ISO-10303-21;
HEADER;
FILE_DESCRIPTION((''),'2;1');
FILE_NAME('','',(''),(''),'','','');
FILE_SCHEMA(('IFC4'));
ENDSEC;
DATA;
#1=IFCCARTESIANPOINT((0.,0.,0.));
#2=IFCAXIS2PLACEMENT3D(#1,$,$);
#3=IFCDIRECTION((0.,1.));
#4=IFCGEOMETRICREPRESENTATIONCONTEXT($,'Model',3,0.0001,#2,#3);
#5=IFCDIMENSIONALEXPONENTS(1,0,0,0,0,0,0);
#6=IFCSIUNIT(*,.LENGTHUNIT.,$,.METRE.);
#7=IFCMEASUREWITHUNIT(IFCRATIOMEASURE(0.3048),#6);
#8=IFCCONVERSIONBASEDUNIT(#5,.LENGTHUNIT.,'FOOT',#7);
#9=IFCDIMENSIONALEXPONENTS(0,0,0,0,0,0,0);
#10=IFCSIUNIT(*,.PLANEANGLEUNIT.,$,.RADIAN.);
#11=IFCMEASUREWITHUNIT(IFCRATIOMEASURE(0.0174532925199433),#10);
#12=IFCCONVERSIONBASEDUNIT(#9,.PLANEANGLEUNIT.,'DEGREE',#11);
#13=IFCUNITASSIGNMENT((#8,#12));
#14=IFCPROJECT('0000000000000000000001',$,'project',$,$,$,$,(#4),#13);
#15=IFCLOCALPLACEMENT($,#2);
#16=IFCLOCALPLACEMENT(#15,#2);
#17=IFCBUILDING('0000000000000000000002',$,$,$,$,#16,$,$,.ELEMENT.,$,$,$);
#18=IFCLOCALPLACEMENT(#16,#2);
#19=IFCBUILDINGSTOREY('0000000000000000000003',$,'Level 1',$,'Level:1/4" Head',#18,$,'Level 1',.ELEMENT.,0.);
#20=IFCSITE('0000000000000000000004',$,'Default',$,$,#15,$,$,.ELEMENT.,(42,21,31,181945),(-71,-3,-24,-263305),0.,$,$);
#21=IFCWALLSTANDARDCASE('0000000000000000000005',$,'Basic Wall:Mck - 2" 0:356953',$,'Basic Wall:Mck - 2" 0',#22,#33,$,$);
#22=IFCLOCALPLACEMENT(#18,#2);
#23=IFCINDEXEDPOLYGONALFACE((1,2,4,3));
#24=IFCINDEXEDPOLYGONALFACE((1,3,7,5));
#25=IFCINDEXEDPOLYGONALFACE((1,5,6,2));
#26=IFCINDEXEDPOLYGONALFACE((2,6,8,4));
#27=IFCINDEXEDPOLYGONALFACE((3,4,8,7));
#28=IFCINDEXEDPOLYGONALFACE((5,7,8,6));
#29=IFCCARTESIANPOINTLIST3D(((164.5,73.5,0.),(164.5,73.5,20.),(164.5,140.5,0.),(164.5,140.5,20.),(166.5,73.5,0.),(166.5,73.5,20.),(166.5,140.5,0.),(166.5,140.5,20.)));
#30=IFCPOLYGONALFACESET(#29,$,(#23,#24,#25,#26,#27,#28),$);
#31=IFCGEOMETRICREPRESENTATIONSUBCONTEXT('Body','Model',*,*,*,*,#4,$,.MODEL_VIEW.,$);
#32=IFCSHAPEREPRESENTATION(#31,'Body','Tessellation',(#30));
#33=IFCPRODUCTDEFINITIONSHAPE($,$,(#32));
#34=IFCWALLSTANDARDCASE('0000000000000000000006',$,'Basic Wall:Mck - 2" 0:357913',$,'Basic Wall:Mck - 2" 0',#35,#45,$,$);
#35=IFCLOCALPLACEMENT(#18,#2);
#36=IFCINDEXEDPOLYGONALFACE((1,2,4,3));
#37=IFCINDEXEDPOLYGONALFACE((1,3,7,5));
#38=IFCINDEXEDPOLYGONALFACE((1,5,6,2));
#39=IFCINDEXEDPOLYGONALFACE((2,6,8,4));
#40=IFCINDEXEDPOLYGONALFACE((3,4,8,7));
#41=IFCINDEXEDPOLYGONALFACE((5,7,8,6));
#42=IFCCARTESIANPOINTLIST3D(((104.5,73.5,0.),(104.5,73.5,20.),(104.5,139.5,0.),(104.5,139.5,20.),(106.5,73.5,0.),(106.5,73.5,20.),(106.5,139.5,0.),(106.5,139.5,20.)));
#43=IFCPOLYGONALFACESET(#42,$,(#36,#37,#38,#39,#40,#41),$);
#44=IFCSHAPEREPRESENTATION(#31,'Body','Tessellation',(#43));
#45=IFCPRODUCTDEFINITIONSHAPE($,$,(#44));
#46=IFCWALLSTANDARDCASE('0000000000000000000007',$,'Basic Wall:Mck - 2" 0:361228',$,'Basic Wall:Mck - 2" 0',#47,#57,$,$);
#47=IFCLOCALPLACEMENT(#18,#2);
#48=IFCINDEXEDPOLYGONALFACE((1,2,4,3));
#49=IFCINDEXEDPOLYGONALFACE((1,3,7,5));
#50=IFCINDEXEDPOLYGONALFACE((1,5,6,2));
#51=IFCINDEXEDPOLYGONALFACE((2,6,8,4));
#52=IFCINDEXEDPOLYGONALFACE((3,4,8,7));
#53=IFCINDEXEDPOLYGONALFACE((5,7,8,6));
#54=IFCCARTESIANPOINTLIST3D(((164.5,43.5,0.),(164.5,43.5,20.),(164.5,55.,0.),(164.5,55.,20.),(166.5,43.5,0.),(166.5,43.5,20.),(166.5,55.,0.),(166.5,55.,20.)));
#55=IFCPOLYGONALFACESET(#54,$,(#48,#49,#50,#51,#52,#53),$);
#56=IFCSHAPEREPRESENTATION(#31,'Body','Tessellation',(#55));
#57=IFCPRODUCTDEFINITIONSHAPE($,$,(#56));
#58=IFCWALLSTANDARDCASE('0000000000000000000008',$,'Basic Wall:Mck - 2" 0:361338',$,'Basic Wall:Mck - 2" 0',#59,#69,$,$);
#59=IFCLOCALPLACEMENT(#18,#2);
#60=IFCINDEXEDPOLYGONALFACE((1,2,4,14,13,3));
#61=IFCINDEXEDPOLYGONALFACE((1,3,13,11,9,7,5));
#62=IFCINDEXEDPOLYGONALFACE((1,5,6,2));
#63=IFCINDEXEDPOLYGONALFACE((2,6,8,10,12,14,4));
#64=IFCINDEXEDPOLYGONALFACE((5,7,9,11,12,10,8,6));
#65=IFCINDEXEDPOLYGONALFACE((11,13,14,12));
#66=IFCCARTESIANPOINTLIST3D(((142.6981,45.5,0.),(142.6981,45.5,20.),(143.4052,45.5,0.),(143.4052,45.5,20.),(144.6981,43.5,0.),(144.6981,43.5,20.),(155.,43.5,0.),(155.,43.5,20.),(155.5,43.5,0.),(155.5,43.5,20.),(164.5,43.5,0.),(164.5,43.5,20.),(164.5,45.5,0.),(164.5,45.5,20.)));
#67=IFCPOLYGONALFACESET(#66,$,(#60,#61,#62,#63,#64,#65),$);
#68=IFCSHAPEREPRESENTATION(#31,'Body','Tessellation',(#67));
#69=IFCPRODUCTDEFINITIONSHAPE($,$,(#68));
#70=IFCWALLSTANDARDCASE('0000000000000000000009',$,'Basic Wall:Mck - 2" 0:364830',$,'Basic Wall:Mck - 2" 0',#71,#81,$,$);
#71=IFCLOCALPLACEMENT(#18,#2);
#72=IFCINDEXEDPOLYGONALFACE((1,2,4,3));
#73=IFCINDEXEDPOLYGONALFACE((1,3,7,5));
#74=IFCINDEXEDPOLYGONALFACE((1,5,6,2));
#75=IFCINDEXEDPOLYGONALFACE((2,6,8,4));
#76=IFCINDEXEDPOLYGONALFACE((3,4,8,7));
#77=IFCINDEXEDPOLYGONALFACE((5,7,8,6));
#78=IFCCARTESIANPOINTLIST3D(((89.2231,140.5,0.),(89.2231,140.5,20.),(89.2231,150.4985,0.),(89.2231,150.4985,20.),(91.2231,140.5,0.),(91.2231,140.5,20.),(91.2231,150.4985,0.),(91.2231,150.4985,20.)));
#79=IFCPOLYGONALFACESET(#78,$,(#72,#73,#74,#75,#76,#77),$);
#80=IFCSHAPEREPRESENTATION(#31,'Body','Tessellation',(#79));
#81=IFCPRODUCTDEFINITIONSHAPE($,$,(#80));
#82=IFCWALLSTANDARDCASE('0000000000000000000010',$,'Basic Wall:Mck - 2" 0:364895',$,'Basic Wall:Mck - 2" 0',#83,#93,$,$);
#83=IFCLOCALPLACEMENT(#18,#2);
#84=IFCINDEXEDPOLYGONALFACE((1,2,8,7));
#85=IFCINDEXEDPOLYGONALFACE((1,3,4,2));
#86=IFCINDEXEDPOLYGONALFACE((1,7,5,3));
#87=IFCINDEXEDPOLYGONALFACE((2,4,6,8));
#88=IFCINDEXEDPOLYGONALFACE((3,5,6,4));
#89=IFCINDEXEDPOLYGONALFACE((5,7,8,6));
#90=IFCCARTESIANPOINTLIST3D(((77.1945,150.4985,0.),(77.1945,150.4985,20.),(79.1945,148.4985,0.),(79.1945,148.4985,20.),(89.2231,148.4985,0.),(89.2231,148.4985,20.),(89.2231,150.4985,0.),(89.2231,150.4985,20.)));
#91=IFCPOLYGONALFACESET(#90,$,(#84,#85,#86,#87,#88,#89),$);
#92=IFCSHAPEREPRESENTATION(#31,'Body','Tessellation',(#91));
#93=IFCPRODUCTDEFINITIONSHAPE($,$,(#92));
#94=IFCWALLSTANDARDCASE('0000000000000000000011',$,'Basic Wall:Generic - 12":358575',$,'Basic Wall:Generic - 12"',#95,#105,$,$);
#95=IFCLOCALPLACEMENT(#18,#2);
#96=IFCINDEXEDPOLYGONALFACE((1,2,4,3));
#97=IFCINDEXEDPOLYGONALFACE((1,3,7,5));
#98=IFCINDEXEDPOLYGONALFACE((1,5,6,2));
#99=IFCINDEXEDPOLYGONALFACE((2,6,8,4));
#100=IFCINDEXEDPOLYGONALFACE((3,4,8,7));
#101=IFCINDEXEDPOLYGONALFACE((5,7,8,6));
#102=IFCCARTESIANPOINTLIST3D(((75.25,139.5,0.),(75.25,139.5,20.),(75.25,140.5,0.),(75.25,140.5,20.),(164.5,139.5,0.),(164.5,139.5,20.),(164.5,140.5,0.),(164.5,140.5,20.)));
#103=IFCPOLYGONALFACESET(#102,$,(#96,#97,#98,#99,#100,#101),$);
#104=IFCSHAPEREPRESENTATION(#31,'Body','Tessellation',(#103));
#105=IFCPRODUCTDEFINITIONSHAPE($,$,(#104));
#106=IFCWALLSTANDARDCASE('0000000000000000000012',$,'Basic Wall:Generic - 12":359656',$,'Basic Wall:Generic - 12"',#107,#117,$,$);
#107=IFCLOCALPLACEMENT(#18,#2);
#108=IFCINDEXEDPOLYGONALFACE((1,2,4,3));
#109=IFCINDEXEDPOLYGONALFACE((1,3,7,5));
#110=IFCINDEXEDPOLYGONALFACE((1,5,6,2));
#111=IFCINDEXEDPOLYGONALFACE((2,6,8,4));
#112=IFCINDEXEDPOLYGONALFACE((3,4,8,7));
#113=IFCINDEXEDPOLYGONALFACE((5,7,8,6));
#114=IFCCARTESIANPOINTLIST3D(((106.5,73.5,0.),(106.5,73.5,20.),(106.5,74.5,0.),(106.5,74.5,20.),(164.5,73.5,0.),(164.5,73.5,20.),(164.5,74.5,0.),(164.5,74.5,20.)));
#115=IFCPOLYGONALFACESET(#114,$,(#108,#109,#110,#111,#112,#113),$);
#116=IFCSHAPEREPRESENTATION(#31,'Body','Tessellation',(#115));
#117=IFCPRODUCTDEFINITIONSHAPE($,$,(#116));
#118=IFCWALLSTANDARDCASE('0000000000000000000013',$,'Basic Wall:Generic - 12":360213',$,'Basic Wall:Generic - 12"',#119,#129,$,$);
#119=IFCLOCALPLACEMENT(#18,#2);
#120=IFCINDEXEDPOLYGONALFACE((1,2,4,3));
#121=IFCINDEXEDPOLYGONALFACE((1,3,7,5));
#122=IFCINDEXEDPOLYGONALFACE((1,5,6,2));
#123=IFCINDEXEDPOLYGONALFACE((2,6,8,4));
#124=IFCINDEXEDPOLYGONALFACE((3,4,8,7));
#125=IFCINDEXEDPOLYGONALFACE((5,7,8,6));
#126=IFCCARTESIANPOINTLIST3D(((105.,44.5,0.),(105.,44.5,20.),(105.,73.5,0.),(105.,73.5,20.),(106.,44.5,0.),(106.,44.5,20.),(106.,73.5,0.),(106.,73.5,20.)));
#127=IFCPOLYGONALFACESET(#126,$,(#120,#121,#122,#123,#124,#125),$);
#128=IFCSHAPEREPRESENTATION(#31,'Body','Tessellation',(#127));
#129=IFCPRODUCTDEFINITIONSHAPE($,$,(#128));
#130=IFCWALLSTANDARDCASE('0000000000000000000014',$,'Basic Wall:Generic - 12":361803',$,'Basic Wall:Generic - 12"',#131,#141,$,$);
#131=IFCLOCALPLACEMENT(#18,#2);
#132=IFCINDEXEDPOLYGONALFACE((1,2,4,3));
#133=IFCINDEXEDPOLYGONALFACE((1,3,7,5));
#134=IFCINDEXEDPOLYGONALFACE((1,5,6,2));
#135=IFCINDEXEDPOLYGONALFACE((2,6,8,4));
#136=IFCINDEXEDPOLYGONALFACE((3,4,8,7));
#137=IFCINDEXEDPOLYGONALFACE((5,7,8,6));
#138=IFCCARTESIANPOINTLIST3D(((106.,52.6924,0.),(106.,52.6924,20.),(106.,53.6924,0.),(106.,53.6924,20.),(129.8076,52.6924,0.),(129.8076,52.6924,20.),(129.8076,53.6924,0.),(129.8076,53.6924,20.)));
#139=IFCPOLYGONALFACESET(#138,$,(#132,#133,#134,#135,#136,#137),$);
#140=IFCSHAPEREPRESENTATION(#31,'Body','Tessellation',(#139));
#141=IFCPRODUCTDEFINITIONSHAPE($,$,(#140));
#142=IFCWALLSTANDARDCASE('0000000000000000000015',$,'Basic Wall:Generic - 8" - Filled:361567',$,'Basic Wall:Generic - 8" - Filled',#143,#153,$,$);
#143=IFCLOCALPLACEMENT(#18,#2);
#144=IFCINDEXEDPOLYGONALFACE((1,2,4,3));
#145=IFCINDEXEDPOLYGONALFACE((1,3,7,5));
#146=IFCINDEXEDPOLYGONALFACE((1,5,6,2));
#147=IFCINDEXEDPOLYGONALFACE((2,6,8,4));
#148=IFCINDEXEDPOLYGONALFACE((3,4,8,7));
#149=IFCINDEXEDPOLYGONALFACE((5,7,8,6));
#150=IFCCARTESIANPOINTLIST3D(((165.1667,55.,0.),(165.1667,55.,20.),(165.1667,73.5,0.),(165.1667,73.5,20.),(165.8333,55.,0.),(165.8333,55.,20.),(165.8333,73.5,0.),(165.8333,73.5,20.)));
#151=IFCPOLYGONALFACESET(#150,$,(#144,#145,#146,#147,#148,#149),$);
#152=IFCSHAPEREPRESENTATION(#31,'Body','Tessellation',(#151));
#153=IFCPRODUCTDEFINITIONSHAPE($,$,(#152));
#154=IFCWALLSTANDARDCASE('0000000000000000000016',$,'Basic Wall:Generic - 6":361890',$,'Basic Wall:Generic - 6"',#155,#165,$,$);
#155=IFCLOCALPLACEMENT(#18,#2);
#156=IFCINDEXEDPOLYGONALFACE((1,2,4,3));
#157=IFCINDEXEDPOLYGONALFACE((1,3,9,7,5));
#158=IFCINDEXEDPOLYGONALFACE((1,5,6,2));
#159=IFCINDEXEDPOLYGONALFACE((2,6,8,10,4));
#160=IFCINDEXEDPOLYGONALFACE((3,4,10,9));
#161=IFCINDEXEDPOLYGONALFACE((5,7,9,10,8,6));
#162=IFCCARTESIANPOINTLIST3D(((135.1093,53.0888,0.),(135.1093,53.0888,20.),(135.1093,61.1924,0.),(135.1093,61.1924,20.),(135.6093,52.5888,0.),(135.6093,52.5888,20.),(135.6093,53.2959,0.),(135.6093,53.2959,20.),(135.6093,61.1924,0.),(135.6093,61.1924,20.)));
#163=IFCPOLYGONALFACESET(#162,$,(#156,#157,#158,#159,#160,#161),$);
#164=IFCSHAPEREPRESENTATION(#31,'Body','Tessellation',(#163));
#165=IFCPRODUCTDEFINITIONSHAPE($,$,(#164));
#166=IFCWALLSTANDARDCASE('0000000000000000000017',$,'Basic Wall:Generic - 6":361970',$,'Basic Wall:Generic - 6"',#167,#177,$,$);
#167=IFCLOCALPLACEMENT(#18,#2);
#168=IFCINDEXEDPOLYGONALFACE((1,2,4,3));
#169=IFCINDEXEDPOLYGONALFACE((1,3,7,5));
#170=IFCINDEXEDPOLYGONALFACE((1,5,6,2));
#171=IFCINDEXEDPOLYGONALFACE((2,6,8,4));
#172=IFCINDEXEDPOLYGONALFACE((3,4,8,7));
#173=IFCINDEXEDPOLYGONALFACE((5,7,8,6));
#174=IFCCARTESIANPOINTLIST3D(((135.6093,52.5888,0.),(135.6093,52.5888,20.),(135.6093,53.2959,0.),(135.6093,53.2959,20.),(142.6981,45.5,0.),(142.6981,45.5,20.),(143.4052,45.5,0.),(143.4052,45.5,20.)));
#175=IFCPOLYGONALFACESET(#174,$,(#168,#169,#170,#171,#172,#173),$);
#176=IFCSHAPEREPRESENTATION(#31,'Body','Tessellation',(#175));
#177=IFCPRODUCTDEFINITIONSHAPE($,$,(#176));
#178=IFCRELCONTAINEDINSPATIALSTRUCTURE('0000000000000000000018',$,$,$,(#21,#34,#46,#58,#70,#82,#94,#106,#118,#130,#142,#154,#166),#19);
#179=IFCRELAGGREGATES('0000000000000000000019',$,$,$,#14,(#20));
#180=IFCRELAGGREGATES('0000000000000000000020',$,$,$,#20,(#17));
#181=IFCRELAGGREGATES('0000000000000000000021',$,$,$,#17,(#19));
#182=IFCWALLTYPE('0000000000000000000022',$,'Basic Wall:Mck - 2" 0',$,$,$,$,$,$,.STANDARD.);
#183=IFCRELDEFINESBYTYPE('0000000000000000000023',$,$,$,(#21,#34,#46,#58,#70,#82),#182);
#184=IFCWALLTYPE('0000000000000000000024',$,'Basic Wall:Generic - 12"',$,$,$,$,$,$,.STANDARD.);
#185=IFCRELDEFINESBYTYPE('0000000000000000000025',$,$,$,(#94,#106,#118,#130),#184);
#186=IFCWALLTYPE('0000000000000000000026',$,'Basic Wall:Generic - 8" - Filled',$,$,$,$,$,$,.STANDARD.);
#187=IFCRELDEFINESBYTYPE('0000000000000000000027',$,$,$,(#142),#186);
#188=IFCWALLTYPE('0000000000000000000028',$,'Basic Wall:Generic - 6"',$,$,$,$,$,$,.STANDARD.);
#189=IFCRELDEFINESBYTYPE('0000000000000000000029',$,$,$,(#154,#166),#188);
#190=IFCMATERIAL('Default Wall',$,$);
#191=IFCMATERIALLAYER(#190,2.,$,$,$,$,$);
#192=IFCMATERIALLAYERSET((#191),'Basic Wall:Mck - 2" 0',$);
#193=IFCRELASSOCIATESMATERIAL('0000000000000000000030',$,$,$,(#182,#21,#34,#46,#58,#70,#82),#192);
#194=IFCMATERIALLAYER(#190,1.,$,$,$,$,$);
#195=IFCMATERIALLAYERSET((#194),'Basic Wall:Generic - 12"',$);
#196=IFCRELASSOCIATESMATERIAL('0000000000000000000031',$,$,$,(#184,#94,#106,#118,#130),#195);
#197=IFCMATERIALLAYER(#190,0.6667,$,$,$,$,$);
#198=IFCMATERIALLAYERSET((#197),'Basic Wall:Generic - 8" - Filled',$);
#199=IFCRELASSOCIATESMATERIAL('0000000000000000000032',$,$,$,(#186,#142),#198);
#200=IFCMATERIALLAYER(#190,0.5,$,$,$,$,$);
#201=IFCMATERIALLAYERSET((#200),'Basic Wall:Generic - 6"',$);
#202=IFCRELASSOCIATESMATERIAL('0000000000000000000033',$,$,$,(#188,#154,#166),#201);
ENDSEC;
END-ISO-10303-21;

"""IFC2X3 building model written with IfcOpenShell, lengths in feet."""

from ifc_helpers import new_model, entity, si_unit, converted_unit, direction, frame, frame_2d, origin, place, context, subcontext, project, spatial, polyline, rectangle, outline, extrude, material, layer, layer_set, layer_usage, type_object, element, save


model = new_model("IFC2X3")

# Units and contexts
model_context = context("Model", 3, precision=0.0001, world=origin(), true_north=direction((0.0, 1.0)))
body_context = subcontext(model_context, "Body", "Model", "MODEL_VIEW")
ifc_project = project(units=[converted_unit("LENGTHUNIT", "FOOT", entity("IfcRatioMeasure", 0.3048), si_unit("LENGTHUNIT", "METRE"), dimensions=[1, 0, 0, 0, 0, 0, 0]), converted_unit("PLANEANGLEUNIT", "DEGREE", entity("IfcRatioMeasure", 0.0174532925199433), si_unit("PLANEANGLEUNIT", "RADIAN"), dimensions=[0, 0, 0, 0, 0, 0, 0])], contexts=[model_context])

# Site, building, storey
site_placement = place(None, origin())
site = spatial("IfcSite", under=ifc_project, at=site_placement, Name="Default", CompositionType="ELEMENT", RefLatitude=(42, 21, 31, 181945), RefLongitude=(-71, -3, -24, -263305), RefElevation=0.0)
building_placement = place(site_placement, origin())
building = spatial("IfcBuilding", under=site, at=building_placement, CompositionType="ELEMENT")
storey_placement = place(building_placement, origin())
storey = spatial("IfcBuildingStorey", under=building, at=storey_placement, Name="Level 1", ObjectType="Level:1/4\" Head", LongName="Level 1", CompositionType="ELEMENT", Elevation=0.0)

# Walls
ifc_material = material(Name="Default Wall")
ifc_layer_1 = layer(ifc_material, 2.0)
ifc_layer_set_1 = layer_set([ifc_layer_1], Name="Basic Wall:Mck - 2\" 0")
ifc_layer_usage_1 = layer_usage(ifc_layer_set_1, "AXIS2", "NEGATIVE", 1.0)
wall_type_1 = type_object("IfcWallType", Name="Basic Wall:Mck - 2\" 0", PredefinedType="STANDARD", material=ifc_layer_set_1)
wall_1_placement = place(storey_placement, frame((165.5, 140.5, 0.0), z_axis=(0.0, 0.0, 1.0), x_axis=(0.0, -1.0, 0.0)))
element("IfcWallStandardCase", 1, at=wall_1_placement, inside=storey, type_object=wall_type_1, material=ifc_layer_usage_1, Name="Basic Wall:Mck - 2\" 0:356953", ObjectType="Basic Wall:Mck - 2\" 0", context=body_context, shape_type="SweptSolid", body=[
    extrude(rectangle(XDim=67.0, YDim=2.0, at=frame_2d((33.5, 0.0), x_axis=(-1.0, 0.0))), origin(), (0.0, 0.0, 1.0), 20.0),
])
ifc_layer_usage_2 = layer_usage(ifc_layer_set_1, "AXIS2", "NEGATIVE", 1.0)
wall_2_placement = place(storey_placement, frame((105.5, 139.5, 0.0), z_axis=(0.0, 0.0, 1.0), x_axis=(0.0, -1.0, 0.0)))
element("IfcWallStandardCase", 2, at=wall_2_placement, inside=storey, type_object=wall_type_1, material=ifc_layer_usage_2, Name="Basic Wall:Mck - 2\" 0:357913", ObjectType="Basic Wall:Mck - 2\" 0", context=body_context, shape_type="SweptSolid", body=[
    extrude(rectangle(XDim=66.0, YDim=2.0, at=frame_2d((33.0, 0.0), x_axis=(-1.0, 0.0))), origin(), (0.0, 0.0, 1.0), 20.0),
])
ifc_layer_usage_3 = layer_usage(ifc_layer_set_1, "AXIS2", "NEGATIVE", 1.0)
wall_3_placement = place(storey_placement, frame((165.5, 55.0, 0.0), z_axis=(0.0, 0.0, 1.0), x_axis=(0.0, -1.0, 0.0)))
element("IfcWallStandardCase", 3, at=wall_3_placement, inside=storey, type_object=wall_type_1, material=ifc_layer_usage_3, Name="Basic Wall:Mck - 2\" 0:361228", ObjectType="Basic Wall:Mck - 2\" 0", context=body_context, shape_type="SweptSolid", body=[
    extrude(rectangle(XDim=11.5, YDim=2.0, at=frame_2d((5.75, 0.0), x_axis=(-1.0, 0.0))), origin(), (0.0, 0.0, 1.0), 20.0),
])
ifc_layer_usage_4 = layer_usage(ifc_layer_set_1, "AXIS2", "NEGATIVE", 1.0)
wall_4_placement = place(storey_placement, frame((164.5, 44.5, 0.0), z_axis=(0.0, 0.0, 1.0), x_axis=(-1.0, 0.0, 0.0)))
element("IfcWallStandardCase", 4, at=wall_4_placement, inside=storey, type_object=wall_type_1, material=ifc_layer_usage_4, Name="Basic Wall:Mck - 2\" 0:361338", ObjectType="Basic Wall:Mck - 2\" 0", context=body_context, shape_type="SweptSolid", body=[
    extrude(outline(polyline([(21.8019, -1.0), (19.8019, 1.0), (9.5, 1.0), (9.0, 1.0), (0.0, 1.0), (0.0, -1.0), (21.0948, -1.0), (21.8019, -1.0)])), origin(), (0.0, 0.0, 1.0), 20.0),
])
ifc_layer_usage_5 = layer_usage(ifc_layer_set_1, "AXIS2", "NEGATIVE", 1.0)
wall_5_placement = place(storey_placement, frame((90.2231, 140.5, 0.0), z_axis=(0.0, 0.0, 1.0), x_axis=(0.0, 1.0, 0.0)))
element("IfcWallStandardCase", 5, at=wall_5_placement, inside=storey, type_object=wall_type_1, material=ifc_layer_usage_5, Name="Basic Wall:Mck - 2\" 0:364830", ObjectType="Basic Wall:Mck - 2\" 0", context=body_context, shape_type="SweptSolid", body=[
    extrude(rectangle(XDim=9.9985, YDim=2.0, at=frame_2d((4.9992, 0.0), x_axis=(-1.0, 0.0))), origin(), (0.0, 0.0, 1.0), 20.0),
])
ifc_layer_usage_6 = layer_usage(ifc_layer_set_1, "AXIS2", "NEGATIVE", 1.0)
wall_6_placement = place(storey_placement, frame((89.2231, 149.4985, 0.0), z_axis=(0.0, 0.0, 1.0), x_axis=(-1.0, 0.0, 0.0)))
element("IfcWallStandardCase", 6, at=wall_6_placement, inside=storey, type_object=wall_type_1, material=ifc_layer_usage_6, Name="Basic Wall:Mck - 2\" 0:364895", ObjectType="Basic Wall:Mck - 2\" 0", context=body_context, shape_type="SweptSolid", body=[
    extrude(outline(polyline([(12.0286, -1.0), (10.0286, 1.0), (0.0, 1.0), (0.0, -1.0), (12.0286, -1.0)])), origin(), (0.0, 0.0, 1.0), 20.0),
])
ifc_layer_2 = layer(ifc_material, 1.0)
ifc_layer_set_2 = layer_set([ifc_layer_2], Name="Basic Wall:Generic - 12\"")
ifc_layer_usage_7 = layer_usage(ifc_layer_set_2, "AXIS2", "NEGATIVE", 0.5)
wall_type_2 = type_object("IfcWallType", Name="Basic Wall:Generic - 12\"", PredefinedType="STANDARD", material=ifc_layer_set_2)
wall_7_placement = place(storey_placement, frame((75.25, 140.0, 0.0)))
element("IfcWallStandardCase", 7, at=wall_7_placement, inside=storey, type_object=wall_type_2, material=ifc_layer_usage_7, Name="Basic Wall:Generic - 12\":358575", ObjectType="Basic Wall:Generic - 12\"", context=body_context, shape_type="SweptSolid", body=[
    extrude(rectangle(XDim=89.25, YDim=1.0, at=frame_2d((44.625, 0.0), x_axis=(-1.0, 0.0))), origin(), (0.0, 0.0, 1.0), 20.0),
])
ifc_layer_usage_8 = layer_usage(ifc_layer_set_2, "AXIS2", "NEGATIVE", 0.5)
wall_8_placement = place(storey_placement, frame((106.5, 74.0, 0.0)))
element("IfcWallStandardCase", 8, at=wall_8_placement, inside=storey, type_object=wall_type_2, material=ifc_layer_usage_8, Name="Basic Wall:Generic - 12\":359656", ObjectType="Basic Wall:Generic - 12\"", context=body_context, shape_type="SweptSolid", body=[
    extrude(rectangle(XDim=58.0, YDim=1.0, at=frame_2d((29.0, 0.0), x_axis=(-1.0, 0.0))), origin(), (0.0, 0.0, 1.0), 20.0),
])
ifc_layer_usage_9 = layer_usage(ifc_layer_set_2, "AXIS2", "NEGATIVE", 0.5)
wall_9_placement = place(storey_placement, frame((105.5, 44.5, 0.0), z_axis=(0.0, 0.0, 1.0), x_axis=(0.0, 1.0, 0.0)))
element("IfcWallStandardCase", 9, at=wall_9_placement, inside=storey, type_object=wall_type_2, material=ifc_layer_usage_9, Name="Basic Wall:Generic - 12\":360213", ObjectType="Basic Wall:Generic - 12\"", context=body_context, shape_type="SweptSolid", body=[
    extrude(rectangle(XDim=29.0, YDim=1.0, at=frame_2d((14.5, 0.0), x_axis=(-1.0, 0.0))), origin(), (0.0, 0.0, 1.0), 20.0),
])
ifc_layer_usage_10 = layer_usage(ifc_layer_set_2, "AXIS2", "NEGATIVE", 0.5)
wall_10_placement = place(storey_placement, frame((129.8076, 53.1924, 0.0), z_axis=(0.0, 0.0, 1.0), x_axis=(-1.0, 0.0, 0.0)))
element("IfcWallStandardCase", 10, at=wall_10_placement, inside=storey, type_object=wall_type_2, material=ifc_layer_usage_10, Name="Basic Wall:Generic - 12\":361803", ObjectType="Basic Wall:Generic - 12\"", context=body_context, shape_type="SweptSolid", body=[
    extrude(rectangle(XDim=23.8076, YDim=1.0, at=frame_2d((11.9038, 0.0), x_axis=(-1.0, 0.0))), origin(), (0.0, 0.0, 1.0), 20.0),
])
ifc_layer_3 = layer(ifc_material, 0.6667)
ifc_layer_set_3 = layer_set([ifc_layer_3], Name="Basic Wall:Generic - 8\" - Filled")
ifc_layer_usage_11 = layer_usage(ifc_layer_set_3, "AXIS2", "NEGATIVE", 0.3333)
wall_type_3 = type_object("IfcWallType", Name="Basic Wall:Generic - 8\" - Filled", PredefinedType="STANDARD", material=ifc_layer_set_3)
wall_11_placement = place(storey_placement, frame((165.5, 55.0, 0.0), z_axis=(0.0, 0.0, 1.0), x_axis=(0.0, 1.0, 0.0)))
element("IfcWallStandardCase", 11, at=wall_11_placement, inside=storey, type_object=wall_type_3, material=ifc_layer_usage_11, Name="Basic Wall:Generic - 8\" - Filled:361567", ObjectType="Basic Wall:Generic - 8\" - Filled", context=body_context, shape_type="SweptSolid", body=[
    extrude(rectangle(XDim=18.5, YDim=0.6667, at=frame_2d((9.25, 0.0), x_axis=(-1.0, 0.0))), origin(), (0.0, 0.0, 1.0), 20.0),
])
ifc_layer_4 = layer(ifc_material, 0.5)
ifc_layer_set_4 = layer_set([ifc_layer_4], Name="Basic Wall:Generic - 6\"")
ifc_layer_usage_12 = layer_usage(ifc_layer_set_4, "AXIS2", "NEGATIVE", 0.25)
wall_type_4 = type_object("IfcWallType", Name="Basic Wall:Generic - 6\"", PredefinedType="STANDARD", material=ifc_layer_set_4)
wall_12_placement = place(storey_placement, frame((135.3593, 61.1924, 0.0), z_axis=(0.0, 0.0, 1.0), x_axis=(0.0, -1.0, 0.0)))
element("IfcWallStandardCase", 12, at=wall_12_placement, inside=storey, type_object=wall_type_4, material=ifc_layer_usage_12, Name="Basic Wall:Generic - 6\":361890", ObjectType="Basic Wall:Generic - 6\"", context=body_context, shape_type="SweptSolid", body=[
    extrude(outline(polyline([(8.1036, -0.25), (8.6036, 0.25), (7.8964, 0.25), (0.0, 0.25), (0.0, -0.25), (8.1036, -0.25)])), origin(), (0.0, 0.0, 1.0), 20.0),
])
ifc_layer_usage_13 = layer_usage(ifc_layer_set_4, "AXIS2", "NEGATIVE", 0.25)
wall_13_placement = place(storey_placement, frame((135.4325, 53.1192, 0.0), z_axis=(0.0, 0.0, 1.0), x_axis=(0.707107, -0.707107, 0.0)))
element("IfcWallStandardCase", 13, at=wall_13_placement, inside=storey, type_object=wall_type_4, material=ifc_layer_usage_13, Name="Basic Wall:Generic - 6\":361970", ObjectType="Basic Wall:Generic - 6\"", context=body_context, shape_type="SweptSolid", body=[
    extrude(outline(polyline([(10.5251, -0.25), (11.0251, 0.25), (0.0, 0.25), (0.5, -0.25), (10.5251, -0.25)])), origin(), (0.0, 0.0, 1.0), 20.0),
])

save(model, "model.ifc")
